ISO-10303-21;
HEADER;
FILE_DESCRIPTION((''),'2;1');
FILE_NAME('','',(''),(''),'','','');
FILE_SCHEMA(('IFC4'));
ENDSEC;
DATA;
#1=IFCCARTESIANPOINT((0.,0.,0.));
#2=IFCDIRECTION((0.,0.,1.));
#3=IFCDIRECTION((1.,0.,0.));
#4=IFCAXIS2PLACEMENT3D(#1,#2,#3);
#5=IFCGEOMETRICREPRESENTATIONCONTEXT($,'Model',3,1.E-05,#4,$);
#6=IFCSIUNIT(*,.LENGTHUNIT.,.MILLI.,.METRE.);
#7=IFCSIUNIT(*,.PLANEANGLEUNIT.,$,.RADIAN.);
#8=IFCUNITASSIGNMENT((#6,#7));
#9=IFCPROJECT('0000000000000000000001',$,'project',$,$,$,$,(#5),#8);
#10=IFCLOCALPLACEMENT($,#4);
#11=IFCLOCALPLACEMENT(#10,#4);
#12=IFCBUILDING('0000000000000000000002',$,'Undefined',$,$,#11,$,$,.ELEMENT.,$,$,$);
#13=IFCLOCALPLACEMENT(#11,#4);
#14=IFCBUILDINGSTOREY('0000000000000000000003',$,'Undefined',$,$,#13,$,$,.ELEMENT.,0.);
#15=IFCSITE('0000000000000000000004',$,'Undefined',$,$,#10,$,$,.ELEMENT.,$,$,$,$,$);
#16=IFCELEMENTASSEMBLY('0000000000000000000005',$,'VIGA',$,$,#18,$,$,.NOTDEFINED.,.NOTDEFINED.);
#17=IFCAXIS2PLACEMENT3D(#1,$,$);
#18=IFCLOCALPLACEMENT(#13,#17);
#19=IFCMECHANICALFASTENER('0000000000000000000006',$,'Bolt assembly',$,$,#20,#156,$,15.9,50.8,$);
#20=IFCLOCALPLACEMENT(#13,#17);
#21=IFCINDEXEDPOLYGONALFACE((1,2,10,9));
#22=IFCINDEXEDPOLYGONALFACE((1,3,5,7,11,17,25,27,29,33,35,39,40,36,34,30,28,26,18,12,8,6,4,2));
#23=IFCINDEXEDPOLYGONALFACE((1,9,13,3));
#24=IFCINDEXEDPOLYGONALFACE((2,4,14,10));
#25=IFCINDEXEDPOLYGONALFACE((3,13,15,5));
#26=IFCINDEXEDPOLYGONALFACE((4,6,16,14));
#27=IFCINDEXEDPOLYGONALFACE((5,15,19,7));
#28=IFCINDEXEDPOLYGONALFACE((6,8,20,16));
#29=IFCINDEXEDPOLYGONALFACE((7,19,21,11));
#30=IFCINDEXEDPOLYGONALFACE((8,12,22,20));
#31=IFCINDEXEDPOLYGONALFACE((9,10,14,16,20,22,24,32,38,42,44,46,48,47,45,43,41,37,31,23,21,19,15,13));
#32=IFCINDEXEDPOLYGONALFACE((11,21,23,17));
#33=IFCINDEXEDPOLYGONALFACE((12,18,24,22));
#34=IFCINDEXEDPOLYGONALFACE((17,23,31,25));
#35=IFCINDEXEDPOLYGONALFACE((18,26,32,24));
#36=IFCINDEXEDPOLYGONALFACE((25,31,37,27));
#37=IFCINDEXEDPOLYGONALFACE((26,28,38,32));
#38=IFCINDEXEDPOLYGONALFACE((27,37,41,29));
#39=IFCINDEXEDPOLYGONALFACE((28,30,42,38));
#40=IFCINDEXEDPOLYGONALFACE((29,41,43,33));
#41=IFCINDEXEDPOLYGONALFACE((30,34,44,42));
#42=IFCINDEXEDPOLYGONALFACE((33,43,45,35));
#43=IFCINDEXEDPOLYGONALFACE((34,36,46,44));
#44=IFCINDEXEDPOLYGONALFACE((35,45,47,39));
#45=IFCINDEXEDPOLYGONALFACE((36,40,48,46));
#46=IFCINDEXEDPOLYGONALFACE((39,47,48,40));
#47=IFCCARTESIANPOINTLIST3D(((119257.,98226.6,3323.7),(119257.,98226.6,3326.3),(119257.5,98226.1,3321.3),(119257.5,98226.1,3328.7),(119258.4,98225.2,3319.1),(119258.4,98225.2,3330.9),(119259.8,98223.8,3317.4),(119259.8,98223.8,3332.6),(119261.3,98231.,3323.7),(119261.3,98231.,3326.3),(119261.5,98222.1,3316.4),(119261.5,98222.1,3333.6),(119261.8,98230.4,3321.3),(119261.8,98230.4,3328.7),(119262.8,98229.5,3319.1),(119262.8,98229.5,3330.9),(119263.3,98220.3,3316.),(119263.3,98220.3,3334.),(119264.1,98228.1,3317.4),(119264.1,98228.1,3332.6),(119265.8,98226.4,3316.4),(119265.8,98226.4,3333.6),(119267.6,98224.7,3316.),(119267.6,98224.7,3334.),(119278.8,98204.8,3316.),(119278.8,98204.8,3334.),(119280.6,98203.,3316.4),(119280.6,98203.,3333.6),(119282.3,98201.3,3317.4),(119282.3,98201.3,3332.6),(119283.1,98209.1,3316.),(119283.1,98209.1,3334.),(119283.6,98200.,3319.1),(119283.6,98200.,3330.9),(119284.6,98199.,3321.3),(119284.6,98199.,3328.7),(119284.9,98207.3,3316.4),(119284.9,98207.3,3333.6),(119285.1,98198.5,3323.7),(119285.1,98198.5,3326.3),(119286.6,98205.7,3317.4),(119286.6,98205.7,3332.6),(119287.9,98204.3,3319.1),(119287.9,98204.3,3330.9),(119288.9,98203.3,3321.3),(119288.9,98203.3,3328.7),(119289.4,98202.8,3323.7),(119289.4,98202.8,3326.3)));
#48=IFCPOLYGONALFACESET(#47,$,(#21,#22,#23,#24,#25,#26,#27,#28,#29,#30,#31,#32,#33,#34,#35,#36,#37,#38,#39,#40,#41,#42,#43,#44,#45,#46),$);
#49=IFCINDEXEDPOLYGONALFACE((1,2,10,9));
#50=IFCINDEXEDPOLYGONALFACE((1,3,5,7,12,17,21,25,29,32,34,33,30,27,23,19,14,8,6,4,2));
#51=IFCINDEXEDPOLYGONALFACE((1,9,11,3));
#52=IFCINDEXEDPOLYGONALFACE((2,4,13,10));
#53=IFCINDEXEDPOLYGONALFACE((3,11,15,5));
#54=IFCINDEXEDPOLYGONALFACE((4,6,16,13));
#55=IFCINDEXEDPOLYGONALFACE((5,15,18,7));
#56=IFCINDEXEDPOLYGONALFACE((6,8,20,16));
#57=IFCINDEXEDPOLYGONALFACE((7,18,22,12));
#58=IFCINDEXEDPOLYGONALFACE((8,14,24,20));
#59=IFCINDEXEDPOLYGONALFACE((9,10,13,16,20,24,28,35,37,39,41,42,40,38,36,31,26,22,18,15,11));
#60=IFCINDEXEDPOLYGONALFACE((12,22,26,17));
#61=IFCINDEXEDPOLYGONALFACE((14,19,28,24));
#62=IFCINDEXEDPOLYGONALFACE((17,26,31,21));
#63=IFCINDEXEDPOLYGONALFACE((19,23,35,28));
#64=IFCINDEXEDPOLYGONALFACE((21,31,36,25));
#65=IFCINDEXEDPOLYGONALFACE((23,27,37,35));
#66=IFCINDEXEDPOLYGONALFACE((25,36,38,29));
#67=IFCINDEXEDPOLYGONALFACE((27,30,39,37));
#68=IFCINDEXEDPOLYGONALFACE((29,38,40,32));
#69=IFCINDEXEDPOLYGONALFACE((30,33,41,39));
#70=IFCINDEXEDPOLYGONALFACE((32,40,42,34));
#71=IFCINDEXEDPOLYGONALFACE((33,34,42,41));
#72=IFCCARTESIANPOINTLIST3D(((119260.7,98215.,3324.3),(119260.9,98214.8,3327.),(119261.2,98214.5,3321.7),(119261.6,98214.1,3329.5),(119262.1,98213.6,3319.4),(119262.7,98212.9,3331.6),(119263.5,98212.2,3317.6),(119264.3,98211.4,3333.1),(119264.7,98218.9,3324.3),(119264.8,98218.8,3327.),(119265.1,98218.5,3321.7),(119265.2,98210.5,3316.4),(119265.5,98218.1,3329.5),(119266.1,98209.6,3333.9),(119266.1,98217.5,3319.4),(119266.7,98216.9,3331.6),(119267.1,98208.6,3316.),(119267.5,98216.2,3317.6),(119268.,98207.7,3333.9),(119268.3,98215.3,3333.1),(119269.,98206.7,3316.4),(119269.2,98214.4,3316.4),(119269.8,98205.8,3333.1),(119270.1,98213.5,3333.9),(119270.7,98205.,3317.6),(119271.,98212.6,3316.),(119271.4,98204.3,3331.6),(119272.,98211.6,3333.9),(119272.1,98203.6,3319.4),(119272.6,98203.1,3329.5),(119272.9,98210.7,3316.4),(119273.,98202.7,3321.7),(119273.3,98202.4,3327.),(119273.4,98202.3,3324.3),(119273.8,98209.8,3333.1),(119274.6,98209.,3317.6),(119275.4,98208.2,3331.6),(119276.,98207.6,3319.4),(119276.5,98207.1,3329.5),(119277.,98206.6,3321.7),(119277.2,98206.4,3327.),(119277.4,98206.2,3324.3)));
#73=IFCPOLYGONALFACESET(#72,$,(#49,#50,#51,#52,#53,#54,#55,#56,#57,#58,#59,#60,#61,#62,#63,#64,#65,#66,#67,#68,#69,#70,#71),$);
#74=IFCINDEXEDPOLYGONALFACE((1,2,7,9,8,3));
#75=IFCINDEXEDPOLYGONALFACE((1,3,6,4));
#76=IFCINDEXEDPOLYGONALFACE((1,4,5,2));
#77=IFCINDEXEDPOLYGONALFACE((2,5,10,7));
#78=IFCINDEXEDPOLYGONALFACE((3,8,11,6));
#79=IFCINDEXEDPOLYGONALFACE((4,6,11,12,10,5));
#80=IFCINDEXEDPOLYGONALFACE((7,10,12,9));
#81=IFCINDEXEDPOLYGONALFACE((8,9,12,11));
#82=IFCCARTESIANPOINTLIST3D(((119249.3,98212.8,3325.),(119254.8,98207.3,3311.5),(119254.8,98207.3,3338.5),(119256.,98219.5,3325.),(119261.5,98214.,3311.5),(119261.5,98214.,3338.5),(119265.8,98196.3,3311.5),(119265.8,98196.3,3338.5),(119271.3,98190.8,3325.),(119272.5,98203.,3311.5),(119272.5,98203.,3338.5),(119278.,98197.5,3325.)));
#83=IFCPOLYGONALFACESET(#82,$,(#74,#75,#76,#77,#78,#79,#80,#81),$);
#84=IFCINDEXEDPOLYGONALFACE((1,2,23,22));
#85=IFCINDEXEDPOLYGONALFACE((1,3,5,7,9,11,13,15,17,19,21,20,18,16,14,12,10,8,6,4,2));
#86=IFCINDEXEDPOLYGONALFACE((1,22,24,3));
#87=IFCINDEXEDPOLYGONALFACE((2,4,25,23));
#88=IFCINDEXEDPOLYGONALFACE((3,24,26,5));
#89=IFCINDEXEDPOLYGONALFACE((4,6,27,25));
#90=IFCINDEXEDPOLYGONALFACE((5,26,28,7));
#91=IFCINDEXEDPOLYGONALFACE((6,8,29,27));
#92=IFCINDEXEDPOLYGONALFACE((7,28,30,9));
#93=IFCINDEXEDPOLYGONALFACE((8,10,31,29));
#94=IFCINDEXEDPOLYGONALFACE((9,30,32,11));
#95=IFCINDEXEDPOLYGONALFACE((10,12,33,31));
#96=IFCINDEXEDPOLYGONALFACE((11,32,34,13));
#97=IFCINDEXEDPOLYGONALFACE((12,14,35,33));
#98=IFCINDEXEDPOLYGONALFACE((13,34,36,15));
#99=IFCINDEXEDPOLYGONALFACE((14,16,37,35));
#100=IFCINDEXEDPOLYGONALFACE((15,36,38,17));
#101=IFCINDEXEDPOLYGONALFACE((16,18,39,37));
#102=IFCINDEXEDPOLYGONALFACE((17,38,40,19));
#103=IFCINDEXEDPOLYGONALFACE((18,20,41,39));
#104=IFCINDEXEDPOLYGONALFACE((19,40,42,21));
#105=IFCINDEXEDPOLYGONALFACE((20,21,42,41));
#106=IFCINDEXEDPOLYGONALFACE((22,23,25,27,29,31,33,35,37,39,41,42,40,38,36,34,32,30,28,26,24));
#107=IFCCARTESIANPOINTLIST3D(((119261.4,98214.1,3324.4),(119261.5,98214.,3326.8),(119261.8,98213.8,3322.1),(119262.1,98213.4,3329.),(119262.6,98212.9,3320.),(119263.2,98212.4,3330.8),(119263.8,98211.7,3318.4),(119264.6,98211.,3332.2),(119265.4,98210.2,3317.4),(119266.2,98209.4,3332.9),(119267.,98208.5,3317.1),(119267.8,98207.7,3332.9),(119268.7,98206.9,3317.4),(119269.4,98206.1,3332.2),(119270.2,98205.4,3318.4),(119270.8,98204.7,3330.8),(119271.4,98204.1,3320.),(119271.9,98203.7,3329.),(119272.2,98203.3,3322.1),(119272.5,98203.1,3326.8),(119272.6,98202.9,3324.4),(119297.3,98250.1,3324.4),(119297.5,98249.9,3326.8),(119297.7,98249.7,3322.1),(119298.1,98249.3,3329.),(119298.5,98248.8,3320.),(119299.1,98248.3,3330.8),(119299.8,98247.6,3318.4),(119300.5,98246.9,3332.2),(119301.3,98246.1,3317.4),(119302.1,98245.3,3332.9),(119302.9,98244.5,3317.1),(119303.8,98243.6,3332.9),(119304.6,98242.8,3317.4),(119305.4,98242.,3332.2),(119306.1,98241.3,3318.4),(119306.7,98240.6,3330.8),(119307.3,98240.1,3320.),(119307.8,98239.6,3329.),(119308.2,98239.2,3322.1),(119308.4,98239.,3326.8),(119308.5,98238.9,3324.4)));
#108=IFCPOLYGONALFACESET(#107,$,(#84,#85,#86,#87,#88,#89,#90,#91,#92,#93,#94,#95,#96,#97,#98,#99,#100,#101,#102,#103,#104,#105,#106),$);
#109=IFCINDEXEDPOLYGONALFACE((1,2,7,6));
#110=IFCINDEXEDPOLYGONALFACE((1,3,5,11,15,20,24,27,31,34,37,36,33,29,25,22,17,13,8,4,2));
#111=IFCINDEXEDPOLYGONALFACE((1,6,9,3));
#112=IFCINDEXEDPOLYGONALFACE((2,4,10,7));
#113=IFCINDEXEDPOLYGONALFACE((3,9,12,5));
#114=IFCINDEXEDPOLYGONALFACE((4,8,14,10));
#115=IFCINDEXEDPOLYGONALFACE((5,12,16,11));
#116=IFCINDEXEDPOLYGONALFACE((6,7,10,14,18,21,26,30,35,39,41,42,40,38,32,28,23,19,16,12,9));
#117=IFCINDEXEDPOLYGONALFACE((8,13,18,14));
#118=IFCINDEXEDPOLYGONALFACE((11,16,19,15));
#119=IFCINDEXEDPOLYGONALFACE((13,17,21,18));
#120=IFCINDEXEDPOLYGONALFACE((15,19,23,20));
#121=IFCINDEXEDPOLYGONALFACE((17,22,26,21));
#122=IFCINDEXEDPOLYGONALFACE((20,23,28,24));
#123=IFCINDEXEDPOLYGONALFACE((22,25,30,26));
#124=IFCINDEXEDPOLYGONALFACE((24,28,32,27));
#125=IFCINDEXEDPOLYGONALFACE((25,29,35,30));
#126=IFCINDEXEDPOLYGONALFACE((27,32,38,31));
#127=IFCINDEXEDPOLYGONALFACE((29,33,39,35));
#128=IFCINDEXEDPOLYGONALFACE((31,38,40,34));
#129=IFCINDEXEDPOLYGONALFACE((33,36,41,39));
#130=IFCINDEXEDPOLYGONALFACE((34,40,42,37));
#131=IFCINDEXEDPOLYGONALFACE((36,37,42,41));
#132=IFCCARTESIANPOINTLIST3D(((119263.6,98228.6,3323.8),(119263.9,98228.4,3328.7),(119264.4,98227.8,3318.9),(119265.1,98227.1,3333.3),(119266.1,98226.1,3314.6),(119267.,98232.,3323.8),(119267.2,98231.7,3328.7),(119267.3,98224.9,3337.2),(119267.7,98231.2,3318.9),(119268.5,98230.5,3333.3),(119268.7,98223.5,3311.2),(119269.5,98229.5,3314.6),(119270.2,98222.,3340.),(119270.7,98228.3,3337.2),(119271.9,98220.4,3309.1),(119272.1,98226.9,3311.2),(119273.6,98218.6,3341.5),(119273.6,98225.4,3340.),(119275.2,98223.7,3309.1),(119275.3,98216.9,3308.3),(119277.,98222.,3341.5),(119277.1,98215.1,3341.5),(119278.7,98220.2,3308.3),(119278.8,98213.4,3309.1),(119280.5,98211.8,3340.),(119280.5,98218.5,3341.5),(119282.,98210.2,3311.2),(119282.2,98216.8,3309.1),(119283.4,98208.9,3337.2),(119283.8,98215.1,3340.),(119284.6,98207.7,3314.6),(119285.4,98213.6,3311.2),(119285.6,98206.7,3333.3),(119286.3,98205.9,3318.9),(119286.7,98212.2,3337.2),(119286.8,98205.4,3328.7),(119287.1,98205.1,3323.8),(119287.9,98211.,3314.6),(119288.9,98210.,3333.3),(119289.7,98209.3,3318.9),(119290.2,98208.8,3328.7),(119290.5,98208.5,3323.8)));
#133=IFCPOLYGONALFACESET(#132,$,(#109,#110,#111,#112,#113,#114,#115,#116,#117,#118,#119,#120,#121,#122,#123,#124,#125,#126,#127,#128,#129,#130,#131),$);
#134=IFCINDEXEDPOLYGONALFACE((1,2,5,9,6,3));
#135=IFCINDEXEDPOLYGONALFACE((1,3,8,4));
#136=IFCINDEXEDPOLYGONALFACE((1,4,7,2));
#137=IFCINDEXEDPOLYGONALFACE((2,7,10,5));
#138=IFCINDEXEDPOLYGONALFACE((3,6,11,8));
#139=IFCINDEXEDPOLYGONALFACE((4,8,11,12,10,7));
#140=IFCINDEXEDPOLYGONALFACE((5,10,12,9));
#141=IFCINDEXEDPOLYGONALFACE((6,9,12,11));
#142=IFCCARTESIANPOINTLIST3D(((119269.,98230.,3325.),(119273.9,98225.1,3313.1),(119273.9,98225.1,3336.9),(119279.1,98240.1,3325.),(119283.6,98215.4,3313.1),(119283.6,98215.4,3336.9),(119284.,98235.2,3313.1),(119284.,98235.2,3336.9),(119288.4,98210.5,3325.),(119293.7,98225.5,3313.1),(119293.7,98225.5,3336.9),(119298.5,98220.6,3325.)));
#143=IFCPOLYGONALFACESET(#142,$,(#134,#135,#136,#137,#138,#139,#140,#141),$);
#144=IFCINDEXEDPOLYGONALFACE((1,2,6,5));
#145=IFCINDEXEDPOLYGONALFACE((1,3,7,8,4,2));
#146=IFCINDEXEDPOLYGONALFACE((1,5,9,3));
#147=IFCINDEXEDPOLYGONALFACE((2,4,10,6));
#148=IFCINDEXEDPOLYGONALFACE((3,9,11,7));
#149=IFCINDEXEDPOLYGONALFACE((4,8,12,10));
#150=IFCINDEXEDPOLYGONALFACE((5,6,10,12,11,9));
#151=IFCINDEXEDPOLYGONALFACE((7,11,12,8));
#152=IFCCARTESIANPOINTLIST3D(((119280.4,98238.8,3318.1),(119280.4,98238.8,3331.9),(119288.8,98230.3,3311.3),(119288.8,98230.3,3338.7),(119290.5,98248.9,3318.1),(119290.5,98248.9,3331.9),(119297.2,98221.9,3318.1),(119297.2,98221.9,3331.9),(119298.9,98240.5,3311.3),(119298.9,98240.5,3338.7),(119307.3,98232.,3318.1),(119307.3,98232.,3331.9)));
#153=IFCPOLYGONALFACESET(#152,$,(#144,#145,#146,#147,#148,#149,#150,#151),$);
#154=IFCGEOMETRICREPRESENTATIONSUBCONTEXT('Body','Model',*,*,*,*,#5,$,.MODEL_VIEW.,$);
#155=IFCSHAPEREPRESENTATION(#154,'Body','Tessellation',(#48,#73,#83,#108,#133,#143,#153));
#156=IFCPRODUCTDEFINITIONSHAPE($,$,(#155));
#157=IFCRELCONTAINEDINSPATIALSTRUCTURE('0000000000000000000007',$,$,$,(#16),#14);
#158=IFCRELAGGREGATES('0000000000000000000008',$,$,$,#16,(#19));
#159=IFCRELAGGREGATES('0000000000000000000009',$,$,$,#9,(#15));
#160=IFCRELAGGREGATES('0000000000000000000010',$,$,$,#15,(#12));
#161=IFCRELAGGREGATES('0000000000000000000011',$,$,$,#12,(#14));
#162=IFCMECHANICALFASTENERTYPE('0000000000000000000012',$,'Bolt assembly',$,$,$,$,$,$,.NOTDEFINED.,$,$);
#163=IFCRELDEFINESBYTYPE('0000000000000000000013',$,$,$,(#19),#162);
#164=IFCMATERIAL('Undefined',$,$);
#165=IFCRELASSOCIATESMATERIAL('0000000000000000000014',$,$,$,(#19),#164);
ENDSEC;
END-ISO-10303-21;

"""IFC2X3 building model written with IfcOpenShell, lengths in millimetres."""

from ifc_helpers import new_model, si_unit, frame, frame_2d, origin_with_axes, origin_2d_with_axis, place, context, subcontext, project, spatial, polyline, circle_curve, parameter, trimmed, segment, composite_curve, circle, outline, extrude, source, transform, mapped, material, type_object, element, aggregate, save


model = new_model("IFC2X3")

# Units and contexts
model_context = context("Model", 3, precision=1e-05, world=origin_with_axes())
body_context = subcontext(model_context, "Body", "Model", "MODEL_VIEW")
ifc_project = project(units=[si_unit("LENGTHUNIT", "METRE", prefix="MILLI"), si_unit("PLANEANGLEUNIT", "RADIAN")], contexts=[model_context])

# Site, building, storey
site_placement = place(None, origin_with_axes())
site = spatial("IfcSite", under=ifc_project, at=site_placement, Name="Undefined", CompositionType="ELEMENT")
building_placement = place(site_placement, origin_with_axes())
building = spatial("IfcBuilding", under=site, at=building_placement, Name="Undefined", CompositionType="ELEMENT")
storey_placement = place(building_placement, origin_with_axes())
storey = spatial("IfcBuildingStorey", under=building, at=storey_placement, Name="Undefined", CompositionType="ELEMENT", Elevation=0.0)

# Element assembly
assembly_1_placement = place(storey_placement, origin_with_axes())
assembly_1 = element("IfcElementAssembly", 1, at=assembly_1_placement, inside=storey, Name="VIGA", AssemblyPlace="NOTDEFINED", PredefinedType="NOTDEFINED")

# Mechanical fastener
ifc_material_1 = material(Name="Undefined")
mechanical_fastener_type = type_object("IfcMechanicalFastenerType", Name="Bolt assembly")
shared_shape_1 = source(origin_with_axes(), body_context, "Body", "SweptSolid", [
    extrude(outline(composite_curve([segment(polyline([(9.0, 11.0), (9.0, -11.0)]), True, "CONTINUOUS"), segment(trimmed(circle_curve(frame_2d((0.0, -11.0), x_axis=(1.0, 0.0)), 9.0), [parameter(0.0)], [parameter(3.141593)], False, "PARAMETER"), True, "CONTINUOUS"), segment(polyline([(-9.0, -11.0), (-9.0, 11.0)]), True, "CONTINUOUS"), segment(trimmed(circle_curve(frame_2d((0.0, 11.0), x_axis=(-1.0, 0.0)), 9.0), [parameter(0.0)], [parameter(3.141593)], False, "PARAMETER"), True, "DISCONTINUOUS")], self_intersect=False)), frame((0.0, 2.9, 0.0), z_axis=(0.0, 1.0, 0.0), x_axis=(1.0, 0.0, 0.0)), (0.0, 0.0, 1.0), 6.1),
    extrude(circle(Radius=9.0, at=origin_2d_with_axis()), frame((0.0, -2.7, 0.0), z_axis=(0.0, 1.0, 0.0), x_axis=(1.0, 0.0, 0.0)), (0.0, 0.0, 1.0), 5.6),
    extrude(outline(polyline([(13.5, -7.8), (13.5, 7.8), (0.0, 15.6), (-13.5, 7.8), (-13.5, -7.8), (0.0, -15.6), (13.5, -7.8)])), frame((0.0, -12.3, 0.0), z_axis=(0.0, 1.0, 0.0), x_axis=(1.0, 0.0, 0.0)), (0.0, 0.0, 1.0), 9.5),
    extrude(circle(Radius=7.9, at=origin_2d_with_axis()), frame((0.0, -2.8, 0.0), z_axis=(0.0, 1.0, 0.0), x_axis=(1.0, 0.0, 0.0)), (0.0, 0.0, 1.0), 50.8),
    extrude(circle(Radius=16.7, at=origin_2d_with_axis()), frame((0.0, 9.0, 0.0), z_axis=(0.0, 1.0, 0.0), x_axis=(1.0, 0.0, 0.0)), (0.0, 0.0, 1.0), 4.8),
    extrude(outline(polyline([(11.9, -6.9), (11.9, 6.9), (0.0, 13.7), (-11.9, 6.9), (-11.9, -6.9), (0.0, -13.7), (11.9, -6.9)])), frame((0.0, 13.8, 0.0), z_axis=(0.0, 1.0, 0.0), x_axis=(1.0, 0.0, 0.0)), (0.0, 0.0, 1.0), 14.3),
    extrude(outline(polyline([(13.7, 0.0), (6.9, 11.9), (-6.9, 11.9), (-13.7, 0.0), (-6.9, -11.9), (6.9, -11.9), (13.7, 0.0)])), frame((0.0, 28.0, 0.0), z_axis=(0.0, 1.0, 0.0), x_axis=(1.0, 0.0, 0.0)), (0.0, 0.0, 1.0), 14.3),
])
mechanical_fastener_1_placement = place(assembly_1_placement, frame((119269.0, 98210.5, 3325.0), z_axis=(0.707107, -0.707106, 0.0), x_axis=(0.0, 0.0, -1.0)))
mechanical_fastener_1 = element("IfcMechanicalFastener", 2, at=mechanical_fastener_1_placement, type_object=mechanical_fastener_type, material=ifc_material_1, Name="Bolt assembly", NominalDiameter=15.9, NominalLength=50.8, context=body_context, shape_type="MappedRepresentation", body=[
    mapped(shared_shape_1, transform((0.0, 0.0, 0.0))),
])
aggregate(assembly_1, [mechanical_fastener_1])

save(model, "model.ifc")
